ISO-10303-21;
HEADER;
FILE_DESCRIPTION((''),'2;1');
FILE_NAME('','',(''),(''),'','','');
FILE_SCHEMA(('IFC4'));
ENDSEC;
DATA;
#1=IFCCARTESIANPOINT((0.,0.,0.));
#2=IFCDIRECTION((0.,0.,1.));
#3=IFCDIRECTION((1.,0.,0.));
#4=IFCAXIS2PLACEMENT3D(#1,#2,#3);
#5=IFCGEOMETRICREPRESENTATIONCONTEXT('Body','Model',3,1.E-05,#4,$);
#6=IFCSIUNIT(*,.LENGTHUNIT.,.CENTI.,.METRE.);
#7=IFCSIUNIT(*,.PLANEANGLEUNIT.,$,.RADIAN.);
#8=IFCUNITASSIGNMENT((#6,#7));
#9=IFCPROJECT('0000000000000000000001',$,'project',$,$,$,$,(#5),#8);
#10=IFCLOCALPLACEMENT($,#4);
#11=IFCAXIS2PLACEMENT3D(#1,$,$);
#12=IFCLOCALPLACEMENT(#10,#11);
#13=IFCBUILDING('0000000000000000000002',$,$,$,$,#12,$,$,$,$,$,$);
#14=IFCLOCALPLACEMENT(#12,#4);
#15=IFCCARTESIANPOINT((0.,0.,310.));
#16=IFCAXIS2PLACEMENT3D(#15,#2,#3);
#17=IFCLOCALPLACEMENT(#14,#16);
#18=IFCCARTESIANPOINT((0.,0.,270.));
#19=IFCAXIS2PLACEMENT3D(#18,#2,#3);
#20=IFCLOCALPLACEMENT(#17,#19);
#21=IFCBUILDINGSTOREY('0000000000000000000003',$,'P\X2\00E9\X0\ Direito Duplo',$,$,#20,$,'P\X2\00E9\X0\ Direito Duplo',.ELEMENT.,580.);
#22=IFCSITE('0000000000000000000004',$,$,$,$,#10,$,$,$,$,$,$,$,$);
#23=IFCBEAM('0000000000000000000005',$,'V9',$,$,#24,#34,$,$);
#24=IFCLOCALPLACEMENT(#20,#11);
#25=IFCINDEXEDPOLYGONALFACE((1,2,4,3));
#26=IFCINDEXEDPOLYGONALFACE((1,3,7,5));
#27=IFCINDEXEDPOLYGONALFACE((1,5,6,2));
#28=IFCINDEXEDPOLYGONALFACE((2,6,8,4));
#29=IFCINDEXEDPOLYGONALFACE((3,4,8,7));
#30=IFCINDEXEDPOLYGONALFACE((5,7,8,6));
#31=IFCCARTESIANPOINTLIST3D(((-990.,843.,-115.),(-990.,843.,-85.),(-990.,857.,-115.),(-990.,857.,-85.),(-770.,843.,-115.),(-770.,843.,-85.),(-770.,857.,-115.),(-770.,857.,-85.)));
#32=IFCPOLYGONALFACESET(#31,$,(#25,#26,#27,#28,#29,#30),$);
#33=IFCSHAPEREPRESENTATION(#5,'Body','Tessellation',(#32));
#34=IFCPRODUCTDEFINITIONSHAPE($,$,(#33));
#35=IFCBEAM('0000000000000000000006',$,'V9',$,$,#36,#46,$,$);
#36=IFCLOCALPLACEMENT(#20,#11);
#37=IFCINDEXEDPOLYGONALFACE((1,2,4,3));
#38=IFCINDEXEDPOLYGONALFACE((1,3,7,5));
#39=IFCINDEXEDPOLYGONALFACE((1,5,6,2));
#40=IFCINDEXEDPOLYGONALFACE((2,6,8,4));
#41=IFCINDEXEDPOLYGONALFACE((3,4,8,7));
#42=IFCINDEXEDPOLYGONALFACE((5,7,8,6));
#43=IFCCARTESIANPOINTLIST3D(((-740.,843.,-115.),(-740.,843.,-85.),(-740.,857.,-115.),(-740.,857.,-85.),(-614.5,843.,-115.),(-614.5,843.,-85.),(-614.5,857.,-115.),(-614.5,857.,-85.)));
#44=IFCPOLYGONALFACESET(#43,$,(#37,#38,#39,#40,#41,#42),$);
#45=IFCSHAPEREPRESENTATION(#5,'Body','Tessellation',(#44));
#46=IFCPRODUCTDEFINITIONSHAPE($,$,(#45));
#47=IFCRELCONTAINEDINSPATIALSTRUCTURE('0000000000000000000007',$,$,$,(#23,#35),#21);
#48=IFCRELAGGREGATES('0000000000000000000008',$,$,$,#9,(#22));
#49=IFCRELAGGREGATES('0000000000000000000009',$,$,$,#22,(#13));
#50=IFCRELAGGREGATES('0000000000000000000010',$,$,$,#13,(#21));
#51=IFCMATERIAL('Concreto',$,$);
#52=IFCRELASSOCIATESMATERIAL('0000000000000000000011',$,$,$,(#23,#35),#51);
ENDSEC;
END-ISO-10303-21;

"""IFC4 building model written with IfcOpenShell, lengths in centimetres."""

from ifc_helpers import new_model, si_unit, frame, origin, origin_with_axes, origin_2d_with_axis, place, context, project, spatial, rectangle, extrude, material, element, save


model = new_model("IFC4")

# Units and contexts
model_context = context("Model", 3, precision=1e-05, world=origin_with_axes(), identifier="Body")
ifc_project = project(units=[si_unit("LENGTHUNIT", "METRE", prefix="CENTI"), si_unit("PLANEANGLEUNIT", "RADIAN")], contexts=[model_context])

# Site, building, storey
site_placement = place(None, origin_with_axes())
site = spatial("IfcSite", under=ifc_project, at=site_placement)
building_placement = place(site_placement, origin())
building = spatial("IfcBuilding", under=site, at=building_placement)
placement_1 = place(building_placement, origin_with_axes())
placement_2 = place(placement_1, frame((0.0, 0.0, 310.0), z_axis=(0.0, 0.0, 1.0), x_axis=(1.0, 0.0, 0.0)))
storey_placement = place(placement_2, frame((0.0, 0.0, 270.0), z_axis=(0.0, 0.0, 1.0), x_axis=(1.0, 0.0, 0.0)))
storey = spatial("IfcBuildingStorey", under=building, at=storey_placement, Name="Pé Direito Duplo", LongName="Pé Direito Duplo", CompositionType="ELEMENT", Elevation=580.0)

# Shared definitions
ifc_material = material(Name="Concreto")

# Beams
beam_1_placement = place(storey_placement, frame((-880.0, 850.0, -85.0), z_axis=(0.0, 0.0, 1.0), x_axis=(1.0, 0.0, 0.0)))
element("IfcBeam", 1, at=beam_1_placement, inside=storey, material=ifc_material, Name="V9", context=model_context, shape_type="SolidModel", body=[
    extrude(rectangle(XDim=14.0, YDim=30.0, at=origin_2d_with_axis()), frame((-110.0, 0.0, -15.0), z_axis=(1.0, 0.0, 0.0), x_axis=(0.0, 1.0, 0.0)), (0.0, 0.0, 1.0), 220.0),
])
beam_2_placement = place(storey_placement, frame((-677.25, 850.0, -85.0), z_axis=(0.0, 0.0, 1.0), x_axis=(1.0, 0.0, 0.0)))
element("IfcBeam", 2, at=beam_2_placement, inside=storey, material=ifc_material, Name="V9", context=model_context, shape_type="SolidModel", body=[
    extrude(rectangle(XDim=14.0, YDim=30.0, at=origin_2d_with_axis()), frame((-62.75, 0.0, -15.0), z_axis=(1.0, 0.0, 0.0), x_axis=(0.0, 1.0, 0.0)), (0.0, 0.0, 1.0), 125.5),
])

save(model, "model.ifc")
